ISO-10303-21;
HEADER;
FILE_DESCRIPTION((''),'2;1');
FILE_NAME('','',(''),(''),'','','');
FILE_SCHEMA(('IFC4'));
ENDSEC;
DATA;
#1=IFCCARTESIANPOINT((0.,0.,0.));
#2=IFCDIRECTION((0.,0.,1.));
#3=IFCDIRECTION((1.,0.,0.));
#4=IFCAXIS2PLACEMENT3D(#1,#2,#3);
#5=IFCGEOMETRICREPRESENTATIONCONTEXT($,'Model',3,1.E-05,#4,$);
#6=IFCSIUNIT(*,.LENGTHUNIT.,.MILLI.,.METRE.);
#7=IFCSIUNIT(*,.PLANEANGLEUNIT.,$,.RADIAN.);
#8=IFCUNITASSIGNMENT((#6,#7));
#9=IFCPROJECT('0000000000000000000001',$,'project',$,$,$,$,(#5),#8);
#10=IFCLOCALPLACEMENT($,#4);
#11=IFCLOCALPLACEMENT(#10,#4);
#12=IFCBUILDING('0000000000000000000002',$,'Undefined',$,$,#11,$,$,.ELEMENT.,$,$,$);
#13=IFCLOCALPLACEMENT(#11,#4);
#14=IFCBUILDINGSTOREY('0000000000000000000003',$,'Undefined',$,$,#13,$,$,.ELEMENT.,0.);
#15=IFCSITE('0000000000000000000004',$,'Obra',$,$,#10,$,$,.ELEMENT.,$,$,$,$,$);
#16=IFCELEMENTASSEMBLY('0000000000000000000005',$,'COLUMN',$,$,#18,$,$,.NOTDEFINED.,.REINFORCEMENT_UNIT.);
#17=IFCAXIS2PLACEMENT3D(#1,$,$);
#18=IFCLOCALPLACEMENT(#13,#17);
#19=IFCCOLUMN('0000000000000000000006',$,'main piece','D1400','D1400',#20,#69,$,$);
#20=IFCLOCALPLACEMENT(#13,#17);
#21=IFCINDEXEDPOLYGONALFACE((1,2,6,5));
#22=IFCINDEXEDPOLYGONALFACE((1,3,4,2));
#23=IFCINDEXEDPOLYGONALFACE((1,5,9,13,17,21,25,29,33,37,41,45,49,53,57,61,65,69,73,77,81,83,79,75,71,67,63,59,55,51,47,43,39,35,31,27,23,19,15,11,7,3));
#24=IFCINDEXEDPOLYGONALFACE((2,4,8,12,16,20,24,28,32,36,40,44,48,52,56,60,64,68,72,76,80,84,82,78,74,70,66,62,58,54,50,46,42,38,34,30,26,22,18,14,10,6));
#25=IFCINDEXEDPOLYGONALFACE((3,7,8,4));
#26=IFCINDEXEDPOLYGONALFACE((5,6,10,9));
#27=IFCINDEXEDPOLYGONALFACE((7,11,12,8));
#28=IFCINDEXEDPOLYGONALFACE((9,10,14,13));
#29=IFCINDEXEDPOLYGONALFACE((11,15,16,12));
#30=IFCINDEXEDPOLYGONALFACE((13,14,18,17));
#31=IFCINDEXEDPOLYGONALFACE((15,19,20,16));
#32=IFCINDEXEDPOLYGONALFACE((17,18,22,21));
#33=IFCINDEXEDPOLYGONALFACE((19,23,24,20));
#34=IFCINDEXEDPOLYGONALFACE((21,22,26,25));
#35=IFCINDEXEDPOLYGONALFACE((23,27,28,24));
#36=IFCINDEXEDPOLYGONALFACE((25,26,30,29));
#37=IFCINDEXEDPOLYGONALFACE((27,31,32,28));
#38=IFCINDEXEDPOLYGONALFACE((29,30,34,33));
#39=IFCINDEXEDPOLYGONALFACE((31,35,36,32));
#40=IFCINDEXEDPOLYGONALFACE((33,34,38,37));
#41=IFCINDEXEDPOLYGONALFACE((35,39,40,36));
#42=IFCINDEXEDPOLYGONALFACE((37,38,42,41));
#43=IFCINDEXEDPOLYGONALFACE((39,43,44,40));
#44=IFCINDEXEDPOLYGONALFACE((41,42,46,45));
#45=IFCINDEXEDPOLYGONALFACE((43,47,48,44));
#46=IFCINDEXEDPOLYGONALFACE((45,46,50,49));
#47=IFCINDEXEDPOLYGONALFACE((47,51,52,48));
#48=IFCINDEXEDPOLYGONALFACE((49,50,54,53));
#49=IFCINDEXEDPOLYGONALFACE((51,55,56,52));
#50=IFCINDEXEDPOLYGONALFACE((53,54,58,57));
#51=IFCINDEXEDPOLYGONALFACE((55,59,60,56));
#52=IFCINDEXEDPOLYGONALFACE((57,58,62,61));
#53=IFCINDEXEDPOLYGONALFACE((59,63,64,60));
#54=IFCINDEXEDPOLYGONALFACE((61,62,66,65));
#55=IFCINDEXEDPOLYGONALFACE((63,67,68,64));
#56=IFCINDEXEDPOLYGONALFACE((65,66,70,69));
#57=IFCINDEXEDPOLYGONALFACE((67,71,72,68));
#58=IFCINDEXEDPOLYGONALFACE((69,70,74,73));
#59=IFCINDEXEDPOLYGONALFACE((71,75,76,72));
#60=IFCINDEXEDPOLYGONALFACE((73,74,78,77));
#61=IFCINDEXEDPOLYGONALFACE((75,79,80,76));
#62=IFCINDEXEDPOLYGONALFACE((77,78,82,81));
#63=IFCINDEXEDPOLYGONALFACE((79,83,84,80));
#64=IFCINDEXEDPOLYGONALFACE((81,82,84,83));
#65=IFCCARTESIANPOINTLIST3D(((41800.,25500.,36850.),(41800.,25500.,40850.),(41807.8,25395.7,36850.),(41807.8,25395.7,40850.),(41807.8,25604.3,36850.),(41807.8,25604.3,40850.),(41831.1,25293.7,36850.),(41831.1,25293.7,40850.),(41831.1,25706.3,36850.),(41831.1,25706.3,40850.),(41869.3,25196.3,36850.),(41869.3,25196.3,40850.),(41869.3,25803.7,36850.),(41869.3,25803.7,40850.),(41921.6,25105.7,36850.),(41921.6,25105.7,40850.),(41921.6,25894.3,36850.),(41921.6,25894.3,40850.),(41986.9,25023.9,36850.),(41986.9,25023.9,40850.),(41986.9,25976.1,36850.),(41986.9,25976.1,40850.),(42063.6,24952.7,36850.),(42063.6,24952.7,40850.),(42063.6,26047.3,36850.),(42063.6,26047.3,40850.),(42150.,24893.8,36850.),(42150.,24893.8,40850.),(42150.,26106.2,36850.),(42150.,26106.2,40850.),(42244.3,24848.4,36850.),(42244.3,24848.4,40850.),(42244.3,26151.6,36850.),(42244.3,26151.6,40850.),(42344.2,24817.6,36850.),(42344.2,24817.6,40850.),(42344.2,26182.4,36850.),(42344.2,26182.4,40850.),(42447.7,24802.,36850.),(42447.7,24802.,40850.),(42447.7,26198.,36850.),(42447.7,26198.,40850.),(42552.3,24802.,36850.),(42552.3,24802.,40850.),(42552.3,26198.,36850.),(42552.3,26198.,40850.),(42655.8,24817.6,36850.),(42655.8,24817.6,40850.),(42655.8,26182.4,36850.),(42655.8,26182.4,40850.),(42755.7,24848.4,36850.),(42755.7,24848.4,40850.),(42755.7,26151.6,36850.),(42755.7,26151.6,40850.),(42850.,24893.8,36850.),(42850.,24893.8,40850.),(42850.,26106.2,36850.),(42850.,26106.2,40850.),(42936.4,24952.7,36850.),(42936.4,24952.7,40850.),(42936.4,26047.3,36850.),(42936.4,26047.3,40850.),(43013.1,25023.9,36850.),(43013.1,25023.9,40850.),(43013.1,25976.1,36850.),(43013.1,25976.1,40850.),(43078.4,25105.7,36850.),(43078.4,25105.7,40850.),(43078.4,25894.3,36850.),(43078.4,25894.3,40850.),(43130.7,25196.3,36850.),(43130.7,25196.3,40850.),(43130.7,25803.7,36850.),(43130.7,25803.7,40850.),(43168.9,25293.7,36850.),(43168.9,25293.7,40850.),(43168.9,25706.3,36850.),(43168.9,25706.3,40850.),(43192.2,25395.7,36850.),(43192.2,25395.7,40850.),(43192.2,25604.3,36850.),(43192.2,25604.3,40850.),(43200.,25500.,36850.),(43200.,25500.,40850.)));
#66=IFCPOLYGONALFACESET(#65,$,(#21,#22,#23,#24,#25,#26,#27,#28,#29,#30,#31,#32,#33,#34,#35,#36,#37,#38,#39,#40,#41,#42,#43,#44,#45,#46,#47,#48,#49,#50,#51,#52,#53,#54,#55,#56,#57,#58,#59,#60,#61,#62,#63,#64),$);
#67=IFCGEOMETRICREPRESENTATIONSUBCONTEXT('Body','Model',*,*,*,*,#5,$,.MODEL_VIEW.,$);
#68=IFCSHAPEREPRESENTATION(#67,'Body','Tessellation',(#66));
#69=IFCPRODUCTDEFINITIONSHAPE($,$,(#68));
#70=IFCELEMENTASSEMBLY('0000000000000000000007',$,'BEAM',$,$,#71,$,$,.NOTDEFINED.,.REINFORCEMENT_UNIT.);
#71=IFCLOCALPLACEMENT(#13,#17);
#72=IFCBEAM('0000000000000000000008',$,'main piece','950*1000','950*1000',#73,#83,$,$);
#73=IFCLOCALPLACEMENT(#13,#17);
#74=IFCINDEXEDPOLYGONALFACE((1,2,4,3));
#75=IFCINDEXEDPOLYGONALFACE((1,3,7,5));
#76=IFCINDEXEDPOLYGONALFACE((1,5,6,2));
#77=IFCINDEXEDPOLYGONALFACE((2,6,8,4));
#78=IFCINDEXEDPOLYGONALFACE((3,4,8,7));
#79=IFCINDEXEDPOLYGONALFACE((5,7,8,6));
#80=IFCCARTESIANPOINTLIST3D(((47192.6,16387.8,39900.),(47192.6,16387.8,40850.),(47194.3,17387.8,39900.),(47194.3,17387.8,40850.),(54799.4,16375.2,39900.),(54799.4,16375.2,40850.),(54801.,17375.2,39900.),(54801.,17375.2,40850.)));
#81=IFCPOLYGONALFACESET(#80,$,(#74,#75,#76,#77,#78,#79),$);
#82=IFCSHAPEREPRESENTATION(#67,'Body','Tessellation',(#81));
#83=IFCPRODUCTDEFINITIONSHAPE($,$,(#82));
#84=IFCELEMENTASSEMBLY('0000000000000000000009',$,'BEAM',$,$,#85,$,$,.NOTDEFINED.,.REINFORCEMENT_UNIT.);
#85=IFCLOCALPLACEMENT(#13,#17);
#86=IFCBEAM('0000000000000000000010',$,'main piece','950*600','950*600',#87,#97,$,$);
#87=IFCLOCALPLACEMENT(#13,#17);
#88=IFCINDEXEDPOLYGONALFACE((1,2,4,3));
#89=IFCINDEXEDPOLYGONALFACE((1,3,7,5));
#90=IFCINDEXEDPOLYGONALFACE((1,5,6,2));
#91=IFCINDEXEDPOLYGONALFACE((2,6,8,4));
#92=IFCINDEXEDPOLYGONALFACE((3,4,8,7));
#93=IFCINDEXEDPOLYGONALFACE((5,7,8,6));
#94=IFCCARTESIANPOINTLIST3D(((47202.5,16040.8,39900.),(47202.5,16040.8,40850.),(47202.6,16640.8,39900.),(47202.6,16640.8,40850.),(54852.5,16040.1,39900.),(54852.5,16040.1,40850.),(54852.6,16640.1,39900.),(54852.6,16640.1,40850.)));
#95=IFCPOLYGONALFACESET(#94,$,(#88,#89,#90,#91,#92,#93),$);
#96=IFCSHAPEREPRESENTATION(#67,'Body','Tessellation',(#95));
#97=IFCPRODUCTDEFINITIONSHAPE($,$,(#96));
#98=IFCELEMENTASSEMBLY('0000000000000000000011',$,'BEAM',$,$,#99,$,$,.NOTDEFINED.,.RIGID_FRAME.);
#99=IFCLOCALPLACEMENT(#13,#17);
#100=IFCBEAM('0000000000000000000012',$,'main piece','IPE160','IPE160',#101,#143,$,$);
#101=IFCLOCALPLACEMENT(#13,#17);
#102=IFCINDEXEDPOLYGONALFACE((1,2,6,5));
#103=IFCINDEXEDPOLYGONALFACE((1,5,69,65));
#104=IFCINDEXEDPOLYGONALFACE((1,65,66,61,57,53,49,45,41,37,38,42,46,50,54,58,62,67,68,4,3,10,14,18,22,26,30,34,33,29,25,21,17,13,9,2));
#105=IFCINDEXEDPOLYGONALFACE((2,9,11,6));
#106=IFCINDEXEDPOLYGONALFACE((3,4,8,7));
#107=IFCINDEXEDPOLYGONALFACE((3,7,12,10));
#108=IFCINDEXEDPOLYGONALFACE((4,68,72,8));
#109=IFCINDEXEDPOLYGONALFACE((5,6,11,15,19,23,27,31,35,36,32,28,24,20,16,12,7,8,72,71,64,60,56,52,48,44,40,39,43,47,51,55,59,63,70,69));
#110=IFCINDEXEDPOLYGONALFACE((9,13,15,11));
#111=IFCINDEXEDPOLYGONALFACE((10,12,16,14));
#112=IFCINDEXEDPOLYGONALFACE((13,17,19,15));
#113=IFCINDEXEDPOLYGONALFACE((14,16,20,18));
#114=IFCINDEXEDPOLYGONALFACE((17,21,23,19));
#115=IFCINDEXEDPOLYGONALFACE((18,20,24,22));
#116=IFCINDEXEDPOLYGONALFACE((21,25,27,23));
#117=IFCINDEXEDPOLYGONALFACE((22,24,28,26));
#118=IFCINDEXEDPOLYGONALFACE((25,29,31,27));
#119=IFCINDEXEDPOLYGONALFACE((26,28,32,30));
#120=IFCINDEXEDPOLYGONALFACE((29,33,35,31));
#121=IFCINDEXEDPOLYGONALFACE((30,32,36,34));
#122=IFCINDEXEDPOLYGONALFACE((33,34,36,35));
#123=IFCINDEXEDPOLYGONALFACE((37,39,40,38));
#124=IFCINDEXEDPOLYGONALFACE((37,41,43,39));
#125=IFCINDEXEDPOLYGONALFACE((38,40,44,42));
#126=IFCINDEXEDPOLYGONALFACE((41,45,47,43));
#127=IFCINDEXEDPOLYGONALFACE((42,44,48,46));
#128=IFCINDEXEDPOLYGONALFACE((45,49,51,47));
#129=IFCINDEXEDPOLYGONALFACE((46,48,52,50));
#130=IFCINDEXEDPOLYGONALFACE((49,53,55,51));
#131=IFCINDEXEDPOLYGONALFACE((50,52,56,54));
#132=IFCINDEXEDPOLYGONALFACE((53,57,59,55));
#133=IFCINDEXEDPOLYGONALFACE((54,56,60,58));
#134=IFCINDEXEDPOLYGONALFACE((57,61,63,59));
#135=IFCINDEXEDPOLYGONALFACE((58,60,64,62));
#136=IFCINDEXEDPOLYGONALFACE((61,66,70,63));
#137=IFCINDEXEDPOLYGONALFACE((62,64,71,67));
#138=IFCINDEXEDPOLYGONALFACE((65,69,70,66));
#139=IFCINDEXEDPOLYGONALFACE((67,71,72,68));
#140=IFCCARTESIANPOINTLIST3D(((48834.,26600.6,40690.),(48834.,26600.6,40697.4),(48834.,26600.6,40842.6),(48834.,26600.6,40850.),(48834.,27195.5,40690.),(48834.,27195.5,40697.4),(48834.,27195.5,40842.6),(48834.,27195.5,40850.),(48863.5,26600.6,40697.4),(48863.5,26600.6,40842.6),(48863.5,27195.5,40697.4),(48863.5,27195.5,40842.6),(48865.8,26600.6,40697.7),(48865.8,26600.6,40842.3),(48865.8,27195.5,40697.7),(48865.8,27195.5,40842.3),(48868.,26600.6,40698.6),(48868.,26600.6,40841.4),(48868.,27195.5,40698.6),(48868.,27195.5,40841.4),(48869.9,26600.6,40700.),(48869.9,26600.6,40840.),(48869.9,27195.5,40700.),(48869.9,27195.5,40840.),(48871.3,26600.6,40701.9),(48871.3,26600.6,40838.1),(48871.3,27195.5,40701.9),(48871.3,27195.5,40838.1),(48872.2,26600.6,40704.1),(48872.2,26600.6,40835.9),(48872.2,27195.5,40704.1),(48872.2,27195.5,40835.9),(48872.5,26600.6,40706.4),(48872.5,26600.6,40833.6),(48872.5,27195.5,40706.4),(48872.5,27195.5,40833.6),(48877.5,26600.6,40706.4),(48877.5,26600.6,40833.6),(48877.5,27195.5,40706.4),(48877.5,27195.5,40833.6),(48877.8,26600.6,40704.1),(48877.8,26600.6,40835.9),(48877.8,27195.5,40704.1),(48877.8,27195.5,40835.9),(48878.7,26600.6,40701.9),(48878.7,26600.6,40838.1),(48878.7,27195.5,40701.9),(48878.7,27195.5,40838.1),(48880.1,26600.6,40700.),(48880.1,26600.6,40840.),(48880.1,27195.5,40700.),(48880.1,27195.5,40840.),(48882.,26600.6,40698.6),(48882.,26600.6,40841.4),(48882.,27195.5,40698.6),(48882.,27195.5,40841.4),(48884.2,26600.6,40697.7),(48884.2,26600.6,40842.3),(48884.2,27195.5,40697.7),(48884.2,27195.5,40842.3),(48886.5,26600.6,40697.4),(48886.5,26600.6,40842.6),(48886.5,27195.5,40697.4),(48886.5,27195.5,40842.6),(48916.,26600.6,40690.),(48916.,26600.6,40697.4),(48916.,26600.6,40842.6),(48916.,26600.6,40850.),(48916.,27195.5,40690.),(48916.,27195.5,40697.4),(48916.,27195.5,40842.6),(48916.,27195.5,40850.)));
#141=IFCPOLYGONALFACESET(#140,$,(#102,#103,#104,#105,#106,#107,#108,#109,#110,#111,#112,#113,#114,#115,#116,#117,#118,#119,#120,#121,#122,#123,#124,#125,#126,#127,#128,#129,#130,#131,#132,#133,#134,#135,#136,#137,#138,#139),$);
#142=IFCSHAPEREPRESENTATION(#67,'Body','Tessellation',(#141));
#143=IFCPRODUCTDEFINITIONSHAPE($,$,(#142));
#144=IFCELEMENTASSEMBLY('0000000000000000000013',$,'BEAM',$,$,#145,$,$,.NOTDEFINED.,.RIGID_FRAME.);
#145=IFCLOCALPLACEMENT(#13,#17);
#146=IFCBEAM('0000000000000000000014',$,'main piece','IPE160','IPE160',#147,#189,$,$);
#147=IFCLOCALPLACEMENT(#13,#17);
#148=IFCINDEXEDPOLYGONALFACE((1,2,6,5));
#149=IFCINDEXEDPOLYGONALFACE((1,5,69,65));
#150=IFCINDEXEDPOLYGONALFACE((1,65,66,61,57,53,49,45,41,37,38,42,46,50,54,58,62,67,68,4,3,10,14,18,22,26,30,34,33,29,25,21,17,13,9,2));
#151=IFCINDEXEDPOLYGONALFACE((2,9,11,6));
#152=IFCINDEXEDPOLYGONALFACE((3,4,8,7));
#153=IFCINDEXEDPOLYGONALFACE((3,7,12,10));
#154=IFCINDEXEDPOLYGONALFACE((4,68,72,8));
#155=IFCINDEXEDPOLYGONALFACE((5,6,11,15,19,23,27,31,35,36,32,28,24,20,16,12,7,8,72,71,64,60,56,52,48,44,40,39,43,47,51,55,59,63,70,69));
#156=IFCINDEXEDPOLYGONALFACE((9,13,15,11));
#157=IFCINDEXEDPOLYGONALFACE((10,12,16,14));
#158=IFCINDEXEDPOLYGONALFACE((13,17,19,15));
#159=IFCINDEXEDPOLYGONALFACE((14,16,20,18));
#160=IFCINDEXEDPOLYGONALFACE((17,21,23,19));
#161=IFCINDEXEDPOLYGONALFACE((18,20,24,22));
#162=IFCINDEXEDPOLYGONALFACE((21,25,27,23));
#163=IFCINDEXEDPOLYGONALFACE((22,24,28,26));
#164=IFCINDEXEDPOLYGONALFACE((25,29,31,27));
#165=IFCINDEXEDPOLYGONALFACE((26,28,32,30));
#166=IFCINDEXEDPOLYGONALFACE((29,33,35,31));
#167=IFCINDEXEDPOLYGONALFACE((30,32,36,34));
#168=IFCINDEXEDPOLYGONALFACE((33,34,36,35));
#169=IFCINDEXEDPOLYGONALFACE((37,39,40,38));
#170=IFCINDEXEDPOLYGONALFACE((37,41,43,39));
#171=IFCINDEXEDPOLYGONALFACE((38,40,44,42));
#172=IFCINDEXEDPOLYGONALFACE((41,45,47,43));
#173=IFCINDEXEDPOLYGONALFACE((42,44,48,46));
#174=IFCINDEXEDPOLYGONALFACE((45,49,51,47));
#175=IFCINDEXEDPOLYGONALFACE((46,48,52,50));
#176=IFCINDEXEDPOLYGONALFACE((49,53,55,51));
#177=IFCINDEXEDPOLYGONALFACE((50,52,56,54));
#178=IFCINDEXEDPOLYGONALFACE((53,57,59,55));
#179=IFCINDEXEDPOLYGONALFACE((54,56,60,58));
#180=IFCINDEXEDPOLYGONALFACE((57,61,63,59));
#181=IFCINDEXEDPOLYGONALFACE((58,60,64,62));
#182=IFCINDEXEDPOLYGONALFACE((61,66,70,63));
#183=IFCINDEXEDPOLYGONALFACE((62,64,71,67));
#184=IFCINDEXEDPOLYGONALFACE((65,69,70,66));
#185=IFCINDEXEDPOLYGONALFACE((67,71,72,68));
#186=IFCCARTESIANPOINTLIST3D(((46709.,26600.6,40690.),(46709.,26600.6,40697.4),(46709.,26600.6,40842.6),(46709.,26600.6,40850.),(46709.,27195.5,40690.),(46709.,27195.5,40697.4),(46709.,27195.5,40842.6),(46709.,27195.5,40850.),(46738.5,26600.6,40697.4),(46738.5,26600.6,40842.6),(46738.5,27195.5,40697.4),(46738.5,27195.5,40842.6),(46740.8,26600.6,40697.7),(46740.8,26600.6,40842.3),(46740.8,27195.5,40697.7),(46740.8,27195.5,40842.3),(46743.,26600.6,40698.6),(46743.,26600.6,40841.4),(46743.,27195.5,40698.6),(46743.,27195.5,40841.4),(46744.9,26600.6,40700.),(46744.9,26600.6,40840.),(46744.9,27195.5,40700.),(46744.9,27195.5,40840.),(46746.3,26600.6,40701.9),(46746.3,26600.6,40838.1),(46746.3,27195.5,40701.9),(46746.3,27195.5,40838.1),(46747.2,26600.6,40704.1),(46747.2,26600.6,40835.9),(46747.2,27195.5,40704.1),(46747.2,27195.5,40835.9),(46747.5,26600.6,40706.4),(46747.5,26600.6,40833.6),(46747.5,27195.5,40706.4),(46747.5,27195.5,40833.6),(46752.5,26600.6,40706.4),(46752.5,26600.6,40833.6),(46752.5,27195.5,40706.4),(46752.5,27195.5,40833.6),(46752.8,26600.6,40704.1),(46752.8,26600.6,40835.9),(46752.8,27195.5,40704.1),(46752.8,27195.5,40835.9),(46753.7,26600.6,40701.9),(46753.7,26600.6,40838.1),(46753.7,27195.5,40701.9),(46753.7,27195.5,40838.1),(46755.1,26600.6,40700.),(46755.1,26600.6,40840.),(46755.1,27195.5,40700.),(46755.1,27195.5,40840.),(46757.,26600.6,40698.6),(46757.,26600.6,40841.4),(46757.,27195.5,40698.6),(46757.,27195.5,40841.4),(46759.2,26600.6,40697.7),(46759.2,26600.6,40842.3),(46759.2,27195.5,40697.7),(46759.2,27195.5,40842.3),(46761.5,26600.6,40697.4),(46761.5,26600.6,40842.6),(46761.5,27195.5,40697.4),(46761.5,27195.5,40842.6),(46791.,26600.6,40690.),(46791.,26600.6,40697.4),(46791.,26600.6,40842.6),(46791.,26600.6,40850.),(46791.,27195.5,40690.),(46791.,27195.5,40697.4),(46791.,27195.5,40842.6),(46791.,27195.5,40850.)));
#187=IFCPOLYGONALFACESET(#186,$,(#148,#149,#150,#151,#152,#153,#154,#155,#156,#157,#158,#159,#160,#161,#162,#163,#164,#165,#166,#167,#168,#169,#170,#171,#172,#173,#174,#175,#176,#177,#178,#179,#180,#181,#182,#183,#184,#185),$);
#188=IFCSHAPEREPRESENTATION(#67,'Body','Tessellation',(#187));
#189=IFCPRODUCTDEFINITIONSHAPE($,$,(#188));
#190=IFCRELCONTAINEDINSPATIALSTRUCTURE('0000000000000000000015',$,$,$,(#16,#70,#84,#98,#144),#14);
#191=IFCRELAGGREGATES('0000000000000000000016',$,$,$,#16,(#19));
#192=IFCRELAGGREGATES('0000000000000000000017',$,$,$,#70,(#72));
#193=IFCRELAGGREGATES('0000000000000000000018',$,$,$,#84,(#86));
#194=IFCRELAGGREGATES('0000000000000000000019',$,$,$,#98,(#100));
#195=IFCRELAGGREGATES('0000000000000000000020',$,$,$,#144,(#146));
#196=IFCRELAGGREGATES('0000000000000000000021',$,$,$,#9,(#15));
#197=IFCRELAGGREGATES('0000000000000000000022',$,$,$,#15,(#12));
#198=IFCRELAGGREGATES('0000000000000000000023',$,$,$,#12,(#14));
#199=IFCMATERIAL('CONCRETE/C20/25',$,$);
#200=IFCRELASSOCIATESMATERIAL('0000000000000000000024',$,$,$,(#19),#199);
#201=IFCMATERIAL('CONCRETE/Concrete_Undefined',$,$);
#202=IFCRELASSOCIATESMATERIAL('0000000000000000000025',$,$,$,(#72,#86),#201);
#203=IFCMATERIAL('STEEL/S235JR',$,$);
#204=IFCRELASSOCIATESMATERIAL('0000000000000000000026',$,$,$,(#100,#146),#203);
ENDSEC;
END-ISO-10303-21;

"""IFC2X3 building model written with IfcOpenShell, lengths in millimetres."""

from ifc_helpers import new_model, si_unit, frame, origin_with_axes, origin_2d_with_axis, place, context, subcontext, project, spatial, rectangle, circle, i_section, extrude, material, element, aggregate, save


model = new_model("IFC2X3")

# Units and contexts
model_context = context("Model", 3, precision=1e-05, world=origin_with_axes())
body_context = subcontext(model_context, "Body", "Model", "MODEL_VIEW")
ifc_project = project(units=[si_unit("LENGTHUNIT", "METRE", prefix="MILLI"), si_unit("PLANEANGLEUNIT", "RADIAN")], contexts=[model_context])

# Site, building, storey
site_placement = place(None, origin_with_axes())
site = spatial("IfcSite", under=ifc_project, at=site_placement, Name="Obra", CompositionType="ELEMENT")
building_placement = place(site_placement, origin_with_axes())
building = spatial("IfcBuilding", under=site, at=building_placement, Name="Undefined", CompositionType="ELEMENT")
storey_placement = place(building_placement, origin_with_axes())
storey = spatial("IfcBuildingStorey", under=building, at=storey_placement, Name="Undefined", CompositionType="ELEMENT", Elevation=0.0)

# Element assembly, column
ifc_material_1 = material(Name="CONCRETE/C20/25")
assembly_1_placement = place(storey_placement, origin_with_axes())
assembly_1 = element("IfcElementAssembly", 1, at=assembly_1_placement, inside=storey, Name="COLUMN", AssemblyPlace="NOTDEFINED", PredefinedType="REINFORCEMENT_UNIT")
column_1_placement = place(assembly_1_placement, frame((42500.0, 25500.0, 36850.0), z_axis=(0.0, 0.0, 1.0), x_axis=(0.0, 1.0, 0.0)))
column_1 = element("IfcColumn", 2, at=column_1_placement, material=ifc_material_1, Name="main piece", Description="D1400", ObjectType="D1400", context=body_context, shape_type="SweptSolid", body=[
    extrude(circle(Radius=700.0, at=origin_2d_with_axis()), frame((0.0, 0.0, 4000.0), z_axis=(0.0, 0.0, -1.0), x_axis=(0.0, 1.0, 0.0)), (0.0, 0.0, 1.0), 4000.0),
])
aggregate(assembly_1, [column_1])

# Element assemblies, beams
assembly_2_placement = place(storey_placement, origin_with_axes())
assembly_2 = element("IfcElementAssembly", 3, at=assembly_2_placement, inside=storey, Name="BEAM", AssemblyPlace="NOTDEFINED", PredefinedType="REINFORCEMENT_UNIT")
ifc_material_2 = material(Name="CONCRETE/Concrete_Undefined")
beam_1_placement = place(assembly_2_placement, frame((47193.5, 16887.8, 40375.0), z_axis=(0.0, 0.0, 1.0), x_axis=(0.999999, -0.001649, 0.0)))
beam_1 = element("IfcBeam", 4, at=beam_1_placement, material=ifc_material_2, Name="main piece", Description="950*1000", ObjectType="950*1000", context=body_context, shape_type="SweptSolid", body=[
    extrude(rectangle(XDim=1000.0, YDim=950.0, at=origin_2d_with_axis()), frame((7606.8, 0.0, 0.0), z_axis=(-1.0, 0.0, 0.0), x_axis=(0.0, -1.0, 0.0)), (0.0, 0.0, 1.0), 7606.8),
])
aggregate(assembly_2, [beam_1])
assembly_3_placement = place(storey_placement, origin_with_axes())
assembly_3 = element("IfcElementAssembly", 5, at=assembly_3_placement, inside=storey, Name="BEAM", AssemblyPlace="NOTDEFINED", PredefinedType="REINFORCEMENT_UNIT")
beam_2_placement = place(assembly_3_placement, frame((47202.6, 16340.8, 40375.0), z_axis=(0.0, 0.0, 1.0), x_axis=(1.0, -0.000098, 0.0)))
beam_2 = element("IfcBeam", 6, at=beam_2_placement, material=ifc_material_2, Name="main piece", Description="950*600", ObjectType="950*600", context=body_context, shape_type="SweptSolid", body=[
    extrude(rectangle(XDim=600.0, YDim=950.0, at=origin_2d_with_axis()), frame((7650.0, 0.0, 0.0), z_axis=(-1.0, 0.0, 0.0), x_axis=(0.0, -1.0, 0.0)), (0.0, 0.0, 1.0), 7650.0),
])
aggregate(assembly_3, [beam_2])
assembly_4_placement = place(storey_placement, origin_with_axes())
assembly_4 = element("IfcElementAssembly", 7, at=assembly_4_placement, inside=storey, Name="BEAM", AssemblyPlace="NOTDEFINED", PredefinedType="RIGID_FRAME")
ifc_material_3 = material(Name="STEEL/S235JR")
beam_3_placement = place(assembly_4_placement, frame((48875.0, 26600.6, 40770.0), z_axis=(0.0, 0.0, 1.0), x_axis=(0.0, 1.0, 0.0)))
beam_3 = element("IfcBeam", 8, at=beam_3_placement, material=ifc_material_3, Name="main piece", Description="IPE160", ObjectType="IPE160", context=body_context, shape_type="SweptSolid", body=[
    extrude(i_section(OverallWidth=82.0, OverallDepth=160.0, WebThickness=5.0, FlangeThickness=7.4, FilletRadius=9.0, at=origin_2d_with_axis()), frame((594.9, 0.0, 0.0), z_axis=(-1.0, 0.0, 0.0), x_axis=(0.0, -1.0, 0.0)), (0.0, 0.0, 1.0), 594.9),
])
aggregate(assembly_4, [beam_3])
assembly_5_placement = place(storey_placement, origin_with_axes())
assembly_5 = element("IfcElementAssembly", 9, at=assembly_5_placement, inside=storey, Name="BEAM", AssemblyPlace="NOTDEFINED", PredefinedType="RIGID_FRAME")
beam_4_placement = place(assembly_5_placement, frame((46750.0, 26600.6, 40770.0), z_axis=(0.0, 0.0, 1.0), x_axis=(0.0, 1.0, 0.0)))
beam_4 = element("IfcBeam", 10, at=beam_4_placement, material=ifc_material_3, Name="main piece", Description="IPE160", ObjectType="IPE160", context=body_context, shape_type="SweptSolid", body=[
    extrude(i_section(OverallWidth=82.0, OverallDepth=160.0, WebThickness=5.0, FlangeThickness=7.4, FilletRadius=9.0, at=origin_2d_with_axis()), frame((594.9, 0.0, 0.0), z_axis=(-1.0, 0.0, 0.0), x_axis=(0.0, -1.0, 0.0)), (0.0, 0.0, 1.0), 594.9),
])
aggregate(assembly_5, [beam_4])

save(model, "model.ifc")
